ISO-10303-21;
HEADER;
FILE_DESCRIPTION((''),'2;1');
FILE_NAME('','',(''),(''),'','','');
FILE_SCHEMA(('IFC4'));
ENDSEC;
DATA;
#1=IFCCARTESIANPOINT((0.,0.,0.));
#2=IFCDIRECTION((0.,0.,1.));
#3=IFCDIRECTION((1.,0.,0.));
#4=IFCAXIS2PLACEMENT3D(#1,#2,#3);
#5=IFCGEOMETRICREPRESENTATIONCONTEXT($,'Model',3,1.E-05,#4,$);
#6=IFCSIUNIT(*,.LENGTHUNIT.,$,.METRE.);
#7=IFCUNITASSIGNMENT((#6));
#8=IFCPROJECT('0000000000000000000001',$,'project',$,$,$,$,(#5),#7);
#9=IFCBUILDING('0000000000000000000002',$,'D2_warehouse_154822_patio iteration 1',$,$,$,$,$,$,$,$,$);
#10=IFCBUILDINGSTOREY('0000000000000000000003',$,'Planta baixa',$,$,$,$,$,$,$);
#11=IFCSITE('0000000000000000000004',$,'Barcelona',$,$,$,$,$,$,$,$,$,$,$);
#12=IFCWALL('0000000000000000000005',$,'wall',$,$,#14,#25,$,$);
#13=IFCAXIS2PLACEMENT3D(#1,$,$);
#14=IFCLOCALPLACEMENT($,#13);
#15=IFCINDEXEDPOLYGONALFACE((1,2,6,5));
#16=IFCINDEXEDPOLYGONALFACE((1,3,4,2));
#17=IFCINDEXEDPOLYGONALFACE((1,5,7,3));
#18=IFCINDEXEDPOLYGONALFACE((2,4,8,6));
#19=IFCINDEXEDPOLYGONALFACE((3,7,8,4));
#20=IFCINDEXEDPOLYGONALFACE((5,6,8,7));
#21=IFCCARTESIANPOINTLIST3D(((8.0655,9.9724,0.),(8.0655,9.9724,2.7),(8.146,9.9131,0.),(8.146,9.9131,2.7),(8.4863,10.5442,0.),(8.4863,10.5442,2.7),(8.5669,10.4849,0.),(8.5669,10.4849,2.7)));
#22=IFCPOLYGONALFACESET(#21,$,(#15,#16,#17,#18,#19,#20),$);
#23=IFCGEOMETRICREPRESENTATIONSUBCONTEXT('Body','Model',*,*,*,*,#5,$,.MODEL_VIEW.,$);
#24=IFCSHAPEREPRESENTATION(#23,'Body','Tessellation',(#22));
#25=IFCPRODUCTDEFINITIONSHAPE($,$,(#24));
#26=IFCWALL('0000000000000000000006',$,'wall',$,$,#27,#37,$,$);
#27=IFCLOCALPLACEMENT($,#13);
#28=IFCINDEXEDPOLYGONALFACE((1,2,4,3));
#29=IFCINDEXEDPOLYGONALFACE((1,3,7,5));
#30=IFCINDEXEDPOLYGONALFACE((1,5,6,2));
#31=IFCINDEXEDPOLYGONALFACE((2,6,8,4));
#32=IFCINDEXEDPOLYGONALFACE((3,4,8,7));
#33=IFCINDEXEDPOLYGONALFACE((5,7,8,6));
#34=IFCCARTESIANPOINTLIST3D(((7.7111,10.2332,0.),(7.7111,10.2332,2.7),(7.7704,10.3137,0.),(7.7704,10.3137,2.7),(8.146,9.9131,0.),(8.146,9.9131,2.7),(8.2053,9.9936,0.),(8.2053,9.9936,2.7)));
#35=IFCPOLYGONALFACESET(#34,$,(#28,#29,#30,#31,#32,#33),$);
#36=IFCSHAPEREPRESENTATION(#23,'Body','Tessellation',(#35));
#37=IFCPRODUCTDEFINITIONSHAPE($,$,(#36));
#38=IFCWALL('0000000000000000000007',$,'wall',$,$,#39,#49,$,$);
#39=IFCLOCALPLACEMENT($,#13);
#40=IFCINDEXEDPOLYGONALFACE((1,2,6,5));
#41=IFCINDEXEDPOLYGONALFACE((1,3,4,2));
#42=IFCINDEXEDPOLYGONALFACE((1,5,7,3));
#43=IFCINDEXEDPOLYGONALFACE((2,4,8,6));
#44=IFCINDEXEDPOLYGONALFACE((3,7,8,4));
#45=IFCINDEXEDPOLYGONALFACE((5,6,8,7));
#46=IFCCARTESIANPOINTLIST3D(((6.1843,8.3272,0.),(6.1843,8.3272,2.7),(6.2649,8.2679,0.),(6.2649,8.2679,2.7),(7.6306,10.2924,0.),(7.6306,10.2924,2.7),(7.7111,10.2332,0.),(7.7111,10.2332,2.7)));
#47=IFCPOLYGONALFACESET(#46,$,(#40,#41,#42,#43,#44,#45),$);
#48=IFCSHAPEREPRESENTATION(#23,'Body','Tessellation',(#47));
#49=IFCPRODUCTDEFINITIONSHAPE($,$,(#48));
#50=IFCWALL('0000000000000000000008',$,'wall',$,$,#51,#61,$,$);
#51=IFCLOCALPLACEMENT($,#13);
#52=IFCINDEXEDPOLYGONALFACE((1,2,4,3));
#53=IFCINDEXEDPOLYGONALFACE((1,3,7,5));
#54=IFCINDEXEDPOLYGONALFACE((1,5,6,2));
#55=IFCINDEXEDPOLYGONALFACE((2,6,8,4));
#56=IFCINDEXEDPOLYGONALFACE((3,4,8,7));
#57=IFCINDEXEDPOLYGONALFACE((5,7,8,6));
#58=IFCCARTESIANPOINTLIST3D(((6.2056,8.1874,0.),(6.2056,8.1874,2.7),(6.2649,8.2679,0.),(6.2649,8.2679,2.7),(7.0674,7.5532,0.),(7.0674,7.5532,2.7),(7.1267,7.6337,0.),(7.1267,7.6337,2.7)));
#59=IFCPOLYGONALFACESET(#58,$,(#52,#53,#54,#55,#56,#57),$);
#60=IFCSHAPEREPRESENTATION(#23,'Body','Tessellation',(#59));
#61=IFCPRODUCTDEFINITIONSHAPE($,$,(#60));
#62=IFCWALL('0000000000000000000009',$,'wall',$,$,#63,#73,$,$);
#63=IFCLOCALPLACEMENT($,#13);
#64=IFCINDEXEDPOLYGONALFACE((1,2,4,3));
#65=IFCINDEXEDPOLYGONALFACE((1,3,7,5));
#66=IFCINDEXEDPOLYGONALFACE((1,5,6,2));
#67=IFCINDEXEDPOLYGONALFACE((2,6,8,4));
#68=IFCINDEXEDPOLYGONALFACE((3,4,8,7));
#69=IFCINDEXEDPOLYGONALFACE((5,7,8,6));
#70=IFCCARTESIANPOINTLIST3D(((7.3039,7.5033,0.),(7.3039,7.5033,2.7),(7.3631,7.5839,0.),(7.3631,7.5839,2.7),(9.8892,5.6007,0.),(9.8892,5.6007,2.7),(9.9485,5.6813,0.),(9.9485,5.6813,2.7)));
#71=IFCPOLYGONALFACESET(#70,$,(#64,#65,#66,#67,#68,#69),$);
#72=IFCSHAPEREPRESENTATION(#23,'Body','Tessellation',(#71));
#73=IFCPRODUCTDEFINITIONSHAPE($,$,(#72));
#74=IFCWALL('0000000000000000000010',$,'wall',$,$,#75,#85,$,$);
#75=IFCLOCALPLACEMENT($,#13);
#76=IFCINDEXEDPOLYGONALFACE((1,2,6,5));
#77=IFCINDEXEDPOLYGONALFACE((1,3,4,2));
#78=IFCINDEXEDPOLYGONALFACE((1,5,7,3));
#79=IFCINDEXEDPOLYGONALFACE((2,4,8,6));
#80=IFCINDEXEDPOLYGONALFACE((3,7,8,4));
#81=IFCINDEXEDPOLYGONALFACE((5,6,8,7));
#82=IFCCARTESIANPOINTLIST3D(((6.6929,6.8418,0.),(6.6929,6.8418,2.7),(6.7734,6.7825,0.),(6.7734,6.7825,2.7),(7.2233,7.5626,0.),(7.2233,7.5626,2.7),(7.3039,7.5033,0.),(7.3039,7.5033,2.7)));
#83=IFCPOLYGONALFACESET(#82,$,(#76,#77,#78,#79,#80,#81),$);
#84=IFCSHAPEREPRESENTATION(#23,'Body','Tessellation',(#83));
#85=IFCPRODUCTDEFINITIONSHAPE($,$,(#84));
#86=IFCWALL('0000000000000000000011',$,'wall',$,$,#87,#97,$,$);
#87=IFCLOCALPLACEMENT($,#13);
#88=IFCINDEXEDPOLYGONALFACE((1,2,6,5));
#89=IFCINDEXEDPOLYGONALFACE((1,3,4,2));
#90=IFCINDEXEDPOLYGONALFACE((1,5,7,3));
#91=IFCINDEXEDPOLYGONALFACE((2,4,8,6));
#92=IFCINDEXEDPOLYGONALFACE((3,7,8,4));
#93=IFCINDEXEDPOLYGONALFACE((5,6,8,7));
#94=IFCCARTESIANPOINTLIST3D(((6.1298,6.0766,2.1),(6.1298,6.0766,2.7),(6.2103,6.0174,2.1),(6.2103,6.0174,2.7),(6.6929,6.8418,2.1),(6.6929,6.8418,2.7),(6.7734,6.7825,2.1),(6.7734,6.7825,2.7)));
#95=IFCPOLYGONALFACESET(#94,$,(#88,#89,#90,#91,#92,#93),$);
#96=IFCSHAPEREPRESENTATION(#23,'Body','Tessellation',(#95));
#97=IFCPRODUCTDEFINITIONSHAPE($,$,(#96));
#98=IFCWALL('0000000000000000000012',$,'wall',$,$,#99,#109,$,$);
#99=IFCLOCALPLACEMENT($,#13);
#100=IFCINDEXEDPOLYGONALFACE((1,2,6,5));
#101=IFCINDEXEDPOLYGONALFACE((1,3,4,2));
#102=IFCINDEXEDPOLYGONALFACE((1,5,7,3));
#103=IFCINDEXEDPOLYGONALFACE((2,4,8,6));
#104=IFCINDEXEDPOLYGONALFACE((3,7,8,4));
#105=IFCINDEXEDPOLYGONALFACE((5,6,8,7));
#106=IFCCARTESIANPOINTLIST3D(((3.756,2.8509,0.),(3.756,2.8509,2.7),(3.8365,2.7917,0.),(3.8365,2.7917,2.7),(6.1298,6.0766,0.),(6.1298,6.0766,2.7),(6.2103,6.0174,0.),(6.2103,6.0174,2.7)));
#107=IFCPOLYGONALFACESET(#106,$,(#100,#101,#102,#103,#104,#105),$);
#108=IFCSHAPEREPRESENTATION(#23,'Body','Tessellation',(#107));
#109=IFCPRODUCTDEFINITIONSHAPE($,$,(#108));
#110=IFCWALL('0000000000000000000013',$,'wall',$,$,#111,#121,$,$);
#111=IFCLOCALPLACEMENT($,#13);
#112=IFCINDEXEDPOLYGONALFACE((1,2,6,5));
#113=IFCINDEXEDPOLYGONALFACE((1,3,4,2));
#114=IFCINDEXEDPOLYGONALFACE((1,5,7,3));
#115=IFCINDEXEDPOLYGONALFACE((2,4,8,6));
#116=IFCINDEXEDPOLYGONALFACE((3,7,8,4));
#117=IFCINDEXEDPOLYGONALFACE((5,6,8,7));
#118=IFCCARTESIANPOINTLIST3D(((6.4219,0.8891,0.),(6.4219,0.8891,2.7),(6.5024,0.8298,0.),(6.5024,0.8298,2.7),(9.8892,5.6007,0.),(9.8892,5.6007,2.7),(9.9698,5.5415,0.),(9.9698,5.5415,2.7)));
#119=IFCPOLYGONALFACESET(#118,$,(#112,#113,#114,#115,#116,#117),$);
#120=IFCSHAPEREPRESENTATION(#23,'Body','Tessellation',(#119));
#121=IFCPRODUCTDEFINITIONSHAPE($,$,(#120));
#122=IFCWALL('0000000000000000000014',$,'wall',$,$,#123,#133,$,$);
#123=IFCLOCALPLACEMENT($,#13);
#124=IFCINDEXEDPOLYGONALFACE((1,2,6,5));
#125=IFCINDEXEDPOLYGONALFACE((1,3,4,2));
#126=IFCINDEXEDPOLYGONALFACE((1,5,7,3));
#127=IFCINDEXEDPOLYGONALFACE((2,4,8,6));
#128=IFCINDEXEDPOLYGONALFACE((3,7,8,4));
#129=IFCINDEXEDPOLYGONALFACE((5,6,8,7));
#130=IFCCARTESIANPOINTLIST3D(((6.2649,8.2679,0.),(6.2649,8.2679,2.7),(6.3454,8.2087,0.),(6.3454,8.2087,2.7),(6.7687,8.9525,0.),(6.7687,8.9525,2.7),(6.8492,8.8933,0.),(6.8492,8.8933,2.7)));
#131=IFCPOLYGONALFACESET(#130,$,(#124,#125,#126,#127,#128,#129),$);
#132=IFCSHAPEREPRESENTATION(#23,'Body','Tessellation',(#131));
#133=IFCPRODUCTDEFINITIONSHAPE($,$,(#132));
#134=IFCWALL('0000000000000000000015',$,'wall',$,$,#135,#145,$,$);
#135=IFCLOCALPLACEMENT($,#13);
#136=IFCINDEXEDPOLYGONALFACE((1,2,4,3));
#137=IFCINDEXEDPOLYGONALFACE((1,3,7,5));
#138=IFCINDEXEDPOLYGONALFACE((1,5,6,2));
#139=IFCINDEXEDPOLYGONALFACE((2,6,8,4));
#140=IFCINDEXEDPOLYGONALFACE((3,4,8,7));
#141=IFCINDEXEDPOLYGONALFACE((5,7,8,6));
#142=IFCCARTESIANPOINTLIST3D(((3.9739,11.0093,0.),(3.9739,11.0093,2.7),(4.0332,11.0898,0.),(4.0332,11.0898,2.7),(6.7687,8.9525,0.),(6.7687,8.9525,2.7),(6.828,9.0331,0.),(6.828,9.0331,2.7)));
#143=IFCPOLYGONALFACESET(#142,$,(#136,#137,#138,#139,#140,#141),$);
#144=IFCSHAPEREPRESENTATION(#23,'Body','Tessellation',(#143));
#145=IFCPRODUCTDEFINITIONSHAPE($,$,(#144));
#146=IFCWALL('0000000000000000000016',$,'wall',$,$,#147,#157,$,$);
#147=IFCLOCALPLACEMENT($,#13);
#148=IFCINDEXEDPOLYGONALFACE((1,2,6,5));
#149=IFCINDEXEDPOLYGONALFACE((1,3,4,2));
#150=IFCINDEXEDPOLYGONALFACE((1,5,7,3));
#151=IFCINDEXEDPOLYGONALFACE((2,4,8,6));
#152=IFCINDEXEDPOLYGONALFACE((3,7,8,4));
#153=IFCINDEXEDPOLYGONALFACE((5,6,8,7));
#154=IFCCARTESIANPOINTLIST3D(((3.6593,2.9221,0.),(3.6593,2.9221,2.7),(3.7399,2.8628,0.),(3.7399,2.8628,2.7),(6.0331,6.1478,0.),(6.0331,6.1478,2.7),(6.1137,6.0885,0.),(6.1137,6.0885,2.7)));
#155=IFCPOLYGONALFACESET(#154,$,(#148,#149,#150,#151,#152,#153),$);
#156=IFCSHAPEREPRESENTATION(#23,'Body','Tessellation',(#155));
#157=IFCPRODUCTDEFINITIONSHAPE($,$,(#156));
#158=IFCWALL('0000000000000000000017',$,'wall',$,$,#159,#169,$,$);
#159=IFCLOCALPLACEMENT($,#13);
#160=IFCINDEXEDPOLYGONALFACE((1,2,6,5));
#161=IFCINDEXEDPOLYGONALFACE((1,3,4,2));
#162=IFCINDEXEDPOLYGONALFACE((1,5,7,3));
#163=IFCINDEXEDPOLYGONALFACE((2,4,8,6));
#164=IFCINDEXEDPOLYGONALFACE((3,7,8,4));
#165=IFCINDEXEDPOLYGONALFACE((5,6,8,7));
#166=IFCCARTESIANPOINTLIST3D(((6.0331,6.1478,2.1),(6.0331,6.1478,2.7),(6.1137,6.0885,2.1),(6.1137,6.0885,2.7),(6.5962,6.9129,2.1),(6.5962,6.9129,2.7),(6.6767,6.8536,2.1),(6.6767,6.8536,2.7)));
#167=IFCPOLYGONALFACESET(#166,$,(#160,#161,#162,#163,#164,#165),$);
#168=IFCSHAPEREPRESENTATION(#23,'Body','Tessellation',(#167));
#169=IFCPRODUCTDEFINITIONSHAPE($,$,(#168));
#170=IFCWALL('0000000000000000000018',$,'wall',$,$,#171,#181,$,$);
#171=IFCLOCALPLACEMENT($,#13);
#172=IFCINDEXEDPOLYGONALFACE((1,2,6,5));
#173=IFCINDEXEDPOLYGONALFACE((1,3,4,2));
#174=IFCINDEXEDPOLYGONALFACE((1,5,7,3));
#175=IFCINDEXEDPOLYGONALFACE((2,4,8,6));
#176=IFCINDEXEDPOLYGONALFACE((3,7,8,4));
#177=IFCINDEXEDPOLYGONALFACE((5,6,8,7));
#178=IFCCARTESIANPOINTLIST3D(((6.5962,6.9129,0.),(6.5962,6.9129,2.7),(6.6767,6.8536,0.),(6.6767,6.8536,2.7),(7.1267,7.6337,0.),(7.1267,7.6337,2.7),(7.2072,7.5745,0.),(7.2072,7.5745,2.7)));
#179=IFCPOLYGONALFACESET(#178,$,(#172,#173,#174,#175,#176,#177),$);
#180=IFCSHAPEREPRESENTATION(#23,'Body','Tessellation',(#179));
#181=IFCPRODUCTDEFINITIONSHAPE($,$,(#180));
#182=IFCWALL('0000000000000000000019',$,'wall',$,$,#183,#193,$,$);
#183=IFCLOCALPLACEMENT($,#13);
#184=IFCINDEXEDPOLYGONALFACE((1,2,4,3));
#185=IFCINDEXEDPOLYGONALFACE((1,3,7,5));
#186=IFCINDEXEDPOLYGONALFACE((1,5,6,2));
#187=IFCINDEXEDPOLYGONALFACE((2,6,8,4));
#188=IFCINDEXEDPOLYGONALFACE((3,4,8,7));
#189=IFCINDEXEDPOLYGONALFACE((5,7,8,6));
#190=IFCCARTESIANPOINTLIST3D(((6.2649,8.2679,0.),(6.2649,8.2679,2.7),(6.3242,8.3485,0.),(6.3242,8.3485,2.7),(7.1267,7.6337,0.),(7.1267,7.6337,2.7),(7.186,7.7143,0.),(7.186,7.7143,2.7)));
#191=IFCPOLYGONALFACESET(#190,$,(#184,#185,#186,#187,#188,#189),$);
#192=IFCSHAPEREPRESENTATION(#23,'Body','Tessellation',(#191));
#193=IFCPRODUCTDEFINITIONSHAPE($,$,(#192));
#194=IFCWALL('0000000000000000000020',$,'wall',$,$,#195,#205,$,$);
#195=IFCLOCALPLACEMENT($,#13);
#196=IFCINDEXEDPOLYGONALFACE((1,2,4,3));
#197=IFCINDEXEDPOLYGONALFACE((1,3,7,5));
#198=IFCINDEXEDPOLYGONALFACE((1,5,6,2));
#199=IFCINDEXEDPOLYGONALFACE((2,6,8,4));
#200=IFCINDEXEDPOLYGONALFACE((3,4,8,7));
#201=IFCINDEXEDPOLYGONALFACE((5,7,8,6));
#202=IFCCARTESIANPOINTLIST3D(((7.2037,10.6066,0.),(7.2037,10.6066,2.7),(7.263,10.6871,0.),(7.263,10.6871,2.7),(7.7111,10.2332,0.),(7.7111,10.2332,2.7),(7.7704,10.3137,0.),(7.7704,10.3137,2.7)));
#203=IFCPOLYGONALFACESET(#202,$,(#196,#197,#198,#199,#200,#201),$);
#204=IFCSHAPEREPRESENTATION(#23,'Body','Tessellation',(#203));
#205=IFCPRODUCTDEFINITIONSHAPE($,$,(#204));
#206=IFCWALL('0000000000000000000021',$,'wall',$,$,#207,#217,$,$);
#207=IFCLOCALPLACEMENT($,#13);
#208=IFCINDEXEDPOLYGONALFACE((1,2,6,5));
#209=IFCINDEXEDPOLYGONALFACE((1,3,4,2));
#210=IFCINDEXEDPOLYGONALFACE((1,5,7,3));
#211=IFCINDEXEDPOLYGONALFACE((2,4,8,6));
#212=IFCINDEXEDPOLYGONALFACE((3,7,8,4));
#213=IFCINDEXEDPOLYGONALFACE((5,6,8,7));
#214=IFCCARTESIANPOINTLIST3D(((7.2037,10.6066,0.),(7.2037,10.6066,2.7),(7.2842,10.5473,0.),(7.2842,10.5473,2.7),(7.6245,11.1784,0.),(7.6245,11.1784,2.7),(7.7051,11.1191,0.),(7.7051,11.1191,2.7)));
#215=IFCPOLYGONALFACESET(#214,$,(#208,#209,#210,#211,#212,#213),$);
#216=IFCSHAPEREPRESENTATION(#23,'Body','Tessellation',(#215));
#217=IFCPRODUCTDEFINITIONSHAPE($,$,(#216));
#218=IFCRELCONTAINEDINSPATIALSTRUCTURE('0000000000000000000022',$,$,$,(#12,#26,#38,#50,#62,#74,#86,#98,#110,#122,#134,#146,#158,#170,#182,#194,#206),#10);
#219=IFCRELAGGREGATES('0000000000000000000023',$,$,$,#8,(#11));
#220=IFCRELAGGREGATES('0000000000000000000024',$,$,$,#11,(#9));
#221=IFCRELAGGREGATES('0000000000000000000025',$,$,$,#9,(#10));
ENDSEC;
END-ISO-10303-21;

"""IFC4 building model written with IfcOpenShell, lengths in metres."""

from ifc_helpers import new_model, si_unit, frame, origin, origin_with_axes, place, context, subcontext, project, spatial, polyline, outline, extrude, element, save


model = new_model("IFC4")

# Units and contexts
model_context = context("Model", 3, precision=1e-05, world=origin_with_axes())
body_context = subcontext(model_context, "Body", "Model", "MODEL_VIEW")
ifc_project = project(units=[si_unit("LENGTHUNIT", "METRE")], contexts=[model_context])

# Site, building, storey
site = spatial("IfcSite", under=ifc_project, Name="Barcelona")
building = spatial("IfcBuilding", under=site, Name="D2_warehouse_154822_patio iteration 1")
storey = spatial("IfcBuildingStorey", under=building, Name="Planta baixa")

# Walls
wall_1_placement = place(None, origin_with_axes())
element("IfcWall", 1, at=wall_1_placement, inside=storey, Name="wall", context=body_context, shape_type="SweptSolid", body=[
    extrude(outline(polyline([(8.5669, 10.4849), (8.146, 9.9131), (8.0655, 9.9724), (8.4863, 10.5442), (8.5669, 10.4849)])), origin(), (0.0, 0.0, 1.0), 2.7),
])
wall_2_placement = place(None, origin_with_axes())
element("IfcWall", 2, at=wall_2_placement, inside=storey, Name="wall", context=body_context, shape_type="SweptSolid", body=[
    extrude(outline(polyline([(8.146, 9.9131), (7.7111, 10.2332), (7.7704, 10.3137), (8.2053, 9.9936), (8.146, 9.9131)])), origin(), (0.0, 0.0, 1.0), 2.7),
])
wall_3_placement = place(None, origin_with_axes())
element("IfcWall", 3, at=wall_3_placement, inside=storey, Name="wall", context=body_context, shape_type="SweptSolid", body=[
    extrude(outline(polyline([(7.7111, 10.2332), (6.2649, 8.2679), (6.1843, 8.3272), (7.6306, 10.2924), (7.7111, 10.2332)])), origin(), (0.0, 0.0, 1.0), 2.7),
])
wall_4_placement = place(None, origin_with_axes())
element("IfcWall", 4, at=wall_4_placement, inside=storey, Name="wall", context=body_context, shape_type="SweptSolid", body=[
    extrude(outline(polyline([(6.2649, 8.2679), (7.1267, 7.6337), (7.0674, 7.5532), (6.2056, 8.1874), (6.2649, 8.2679)])), origin(), (0.0, 0.0, 1.0), 2.7),
])
wall_5_placement = place(None, origin_with_axes())
element("IfcWall", 5, at=wall_5_placement, inside=storey, Name="wall", context=body_context, shape_type="SweptSolid", body=[
    extrude(outline(polyline([(9.8892, 5.6007), (7.3039, 7.5033), (7.3631, 7.5839), (9.9485, 5.6813), (9.8892, 5.6007)])), origin(), (0.0, 0.0, 1.0), 2.7),
])
wall_6_placement = place(None, origin_with_axes())
element("IfcWall", 6, at=wall_6_placement, inside=storey, Name="wall", context=body_context, shape_type="SweptSolid", body=[
    extrude(outline(polyline([(7.3039, 7.5033), (6.7734, 6.7825), (6.6929, 6.8418), (7.2233, 7.5626), (7.3039, 7.5033)])), origin(), (0.0, 0.0, 1.0), 2.7),
])
wall_7_placement = place(None, origin_with_axes())
element("IfcWall", 7, at=wall_7_placement, inside=storey, Name="wall", context=body_context, shape_type="SweptSolid", body=[
    extrude(outline(polyline([(6.7734, 6.7825), (6.2103, 6.0174), (6.1298, 6.0766), (6.6929, 6.8418), (6.7734, 6.7825)])), frame((0.0, 0.0, 2.1)), (0.0, 0.0, 1.0), 0.6),
])
wall_8_placement = place(None, origin_with_axes())
element("IfcWall", 8, at=wall_8_placement, inside=storey, Name="wall", context=body_context, shape_type="SweptSolid", body=[
    extrude(outline(polyline([(6.2103, 6.0174), (3.8365, 2.7917), (3.756, 2.8509), (6.1298, 6.0766), (6.2103, 6.0174)])), origin(), (0.0, 0.0, 1.0), 2.7),
])
wall_9_placement = place(None, origin_with_axes())
element("IfcWall", 9, at=wall_9_placement, inside=storey, Name="wall", context=body_context, shape_type="SweptSolid", body=[
    extrude(outline(polyline([(6.4219, 0.8891), (9.8892, 5.6007), (9.9698, 5.5415), (6.5024, 0.8298), (6.4219, 0.8891)])), origin(), (0.0, 0.0, 1.0), 2.7),
])
wall_10_placement = place(None, origin_with_axes())
element("IfcWall", 10, at=wall_10_placement, inside=storey, Name="wall", context=body_context, shape_type="SweptSolid", body=[
    extrude(outline(polyline([(6.2649, 8.2679), (6.7687, 8.9525), (6.8492, 8.8933), (6.3454, 8.2087), (6.2649, 8.2679)])), origin(), (0.0, 0.0, 1.0), 2.7),
])
wall_11_placement = place(None, origin_with_axes())
element("IfcWall", 11, at=wall_11_placement, inside=storey, Name="wall", context=body_context, shape_type="SweptSolid", body=[
    extrude(outline(polyline([(6.7687, 8.9525), (3.9739, 11.0093), (4.0332, 11.0898), (6.828, 9.0331), (6.7687, 8.9525)])), origin(), (0.0, 0.0, 1.0), 2.7),
])
wall_12_placement = place(None, origin_with_axes())
element("IfcWall", 12, at=wall_12_placement, inside=storey, Name="wall", context=body_context, shape_type="SweptSolid", body=[
    extrude(outline(polyline([(3.6593, 2.9221), (6.0331, 6.1478), (6.1137, 6.0885), (3.7399, 2.8628), (3.6593, 2.9221)])), origin(), (0.0, 0.0, 1.0), 2.7),
])
wall_13_placement = place(None, origin_with_axes())
element("IfcWall", 13, at=wall_13_placement, inside=storey, Name="wall", context=body_context, shape_type="SweptSolid", body=[
    extrude(outline(polyline([(6.0331, 6.1478), (6.5962, 6.9129), (6.6767, 6.8536), (6.1137, 6.0885), (6.0331, 6.1478)])), frame((0.0, 0.0, 2.1)), (0.0, 0.0, 1.0), 0.6),
])
wall_14_placement = place(None, origin_with_axes())
element("IfcWall", 14, at=wall_14_placement, inside=storey, Name="wall", context=body_context, shape_type="SweptSolid", body=[
    extrude(outline(polyline([(6.5962, 6.9129), (7.1267, 7.6337), (7.2072, 7.5745), (6.6767, 6.8536), (6.5962, 6.9129)])), origin(), (0.0, 0.0, 1.0), 2.7),
])
wall_15_placement = place(None, origin_with_axes())
element("IfcWall", 15, at=wall_15_placement, inside=storey, Name="wall", context=body_context, shape_type="SweptSolid", body=[
    extrude(outline(polyline([(7.1267, 7.6337), (6.2649, 8.2679), (6.3242, 8.3485), (7.186, 7.7143), (7.1267, 7.6337)])), origin(), (0.0, 0.0, 1.0), 2.7),
])
wall_16_placement = place(None, origin_with_axes())
element("IfcWall", 16, at=wall_16_placement, inside=storey, Name="wall", context=body_context, shape_type="SweptSolid", body=[
    extrude(outline(polyline([(7.7111, 10.2332), (7.2037, 10.6066), (7.263, 10.6871), (7.7704, 10.3137), (7.7111, 10.2332)])), origin(), (0.0, 0.0, 1.0), 2.7),
])
wall_17_placement = place(None, origin_with_axes())
element("IfcWall", 17, at=wall_17_placement, inside=storey, Name="wall", context=body_context, shape_type="SweptSolid", body=[
    extrude(outline(polyline([(7.2037, 10.6066), (7.6245, 11.1784), (7.7051, 11.1191), (7.2842, 10.5473), (7.2037, 10.6066)])), origin(), (0.0, 0.0, 1.0), 2.7),
])

save(model, "model.ifc")
